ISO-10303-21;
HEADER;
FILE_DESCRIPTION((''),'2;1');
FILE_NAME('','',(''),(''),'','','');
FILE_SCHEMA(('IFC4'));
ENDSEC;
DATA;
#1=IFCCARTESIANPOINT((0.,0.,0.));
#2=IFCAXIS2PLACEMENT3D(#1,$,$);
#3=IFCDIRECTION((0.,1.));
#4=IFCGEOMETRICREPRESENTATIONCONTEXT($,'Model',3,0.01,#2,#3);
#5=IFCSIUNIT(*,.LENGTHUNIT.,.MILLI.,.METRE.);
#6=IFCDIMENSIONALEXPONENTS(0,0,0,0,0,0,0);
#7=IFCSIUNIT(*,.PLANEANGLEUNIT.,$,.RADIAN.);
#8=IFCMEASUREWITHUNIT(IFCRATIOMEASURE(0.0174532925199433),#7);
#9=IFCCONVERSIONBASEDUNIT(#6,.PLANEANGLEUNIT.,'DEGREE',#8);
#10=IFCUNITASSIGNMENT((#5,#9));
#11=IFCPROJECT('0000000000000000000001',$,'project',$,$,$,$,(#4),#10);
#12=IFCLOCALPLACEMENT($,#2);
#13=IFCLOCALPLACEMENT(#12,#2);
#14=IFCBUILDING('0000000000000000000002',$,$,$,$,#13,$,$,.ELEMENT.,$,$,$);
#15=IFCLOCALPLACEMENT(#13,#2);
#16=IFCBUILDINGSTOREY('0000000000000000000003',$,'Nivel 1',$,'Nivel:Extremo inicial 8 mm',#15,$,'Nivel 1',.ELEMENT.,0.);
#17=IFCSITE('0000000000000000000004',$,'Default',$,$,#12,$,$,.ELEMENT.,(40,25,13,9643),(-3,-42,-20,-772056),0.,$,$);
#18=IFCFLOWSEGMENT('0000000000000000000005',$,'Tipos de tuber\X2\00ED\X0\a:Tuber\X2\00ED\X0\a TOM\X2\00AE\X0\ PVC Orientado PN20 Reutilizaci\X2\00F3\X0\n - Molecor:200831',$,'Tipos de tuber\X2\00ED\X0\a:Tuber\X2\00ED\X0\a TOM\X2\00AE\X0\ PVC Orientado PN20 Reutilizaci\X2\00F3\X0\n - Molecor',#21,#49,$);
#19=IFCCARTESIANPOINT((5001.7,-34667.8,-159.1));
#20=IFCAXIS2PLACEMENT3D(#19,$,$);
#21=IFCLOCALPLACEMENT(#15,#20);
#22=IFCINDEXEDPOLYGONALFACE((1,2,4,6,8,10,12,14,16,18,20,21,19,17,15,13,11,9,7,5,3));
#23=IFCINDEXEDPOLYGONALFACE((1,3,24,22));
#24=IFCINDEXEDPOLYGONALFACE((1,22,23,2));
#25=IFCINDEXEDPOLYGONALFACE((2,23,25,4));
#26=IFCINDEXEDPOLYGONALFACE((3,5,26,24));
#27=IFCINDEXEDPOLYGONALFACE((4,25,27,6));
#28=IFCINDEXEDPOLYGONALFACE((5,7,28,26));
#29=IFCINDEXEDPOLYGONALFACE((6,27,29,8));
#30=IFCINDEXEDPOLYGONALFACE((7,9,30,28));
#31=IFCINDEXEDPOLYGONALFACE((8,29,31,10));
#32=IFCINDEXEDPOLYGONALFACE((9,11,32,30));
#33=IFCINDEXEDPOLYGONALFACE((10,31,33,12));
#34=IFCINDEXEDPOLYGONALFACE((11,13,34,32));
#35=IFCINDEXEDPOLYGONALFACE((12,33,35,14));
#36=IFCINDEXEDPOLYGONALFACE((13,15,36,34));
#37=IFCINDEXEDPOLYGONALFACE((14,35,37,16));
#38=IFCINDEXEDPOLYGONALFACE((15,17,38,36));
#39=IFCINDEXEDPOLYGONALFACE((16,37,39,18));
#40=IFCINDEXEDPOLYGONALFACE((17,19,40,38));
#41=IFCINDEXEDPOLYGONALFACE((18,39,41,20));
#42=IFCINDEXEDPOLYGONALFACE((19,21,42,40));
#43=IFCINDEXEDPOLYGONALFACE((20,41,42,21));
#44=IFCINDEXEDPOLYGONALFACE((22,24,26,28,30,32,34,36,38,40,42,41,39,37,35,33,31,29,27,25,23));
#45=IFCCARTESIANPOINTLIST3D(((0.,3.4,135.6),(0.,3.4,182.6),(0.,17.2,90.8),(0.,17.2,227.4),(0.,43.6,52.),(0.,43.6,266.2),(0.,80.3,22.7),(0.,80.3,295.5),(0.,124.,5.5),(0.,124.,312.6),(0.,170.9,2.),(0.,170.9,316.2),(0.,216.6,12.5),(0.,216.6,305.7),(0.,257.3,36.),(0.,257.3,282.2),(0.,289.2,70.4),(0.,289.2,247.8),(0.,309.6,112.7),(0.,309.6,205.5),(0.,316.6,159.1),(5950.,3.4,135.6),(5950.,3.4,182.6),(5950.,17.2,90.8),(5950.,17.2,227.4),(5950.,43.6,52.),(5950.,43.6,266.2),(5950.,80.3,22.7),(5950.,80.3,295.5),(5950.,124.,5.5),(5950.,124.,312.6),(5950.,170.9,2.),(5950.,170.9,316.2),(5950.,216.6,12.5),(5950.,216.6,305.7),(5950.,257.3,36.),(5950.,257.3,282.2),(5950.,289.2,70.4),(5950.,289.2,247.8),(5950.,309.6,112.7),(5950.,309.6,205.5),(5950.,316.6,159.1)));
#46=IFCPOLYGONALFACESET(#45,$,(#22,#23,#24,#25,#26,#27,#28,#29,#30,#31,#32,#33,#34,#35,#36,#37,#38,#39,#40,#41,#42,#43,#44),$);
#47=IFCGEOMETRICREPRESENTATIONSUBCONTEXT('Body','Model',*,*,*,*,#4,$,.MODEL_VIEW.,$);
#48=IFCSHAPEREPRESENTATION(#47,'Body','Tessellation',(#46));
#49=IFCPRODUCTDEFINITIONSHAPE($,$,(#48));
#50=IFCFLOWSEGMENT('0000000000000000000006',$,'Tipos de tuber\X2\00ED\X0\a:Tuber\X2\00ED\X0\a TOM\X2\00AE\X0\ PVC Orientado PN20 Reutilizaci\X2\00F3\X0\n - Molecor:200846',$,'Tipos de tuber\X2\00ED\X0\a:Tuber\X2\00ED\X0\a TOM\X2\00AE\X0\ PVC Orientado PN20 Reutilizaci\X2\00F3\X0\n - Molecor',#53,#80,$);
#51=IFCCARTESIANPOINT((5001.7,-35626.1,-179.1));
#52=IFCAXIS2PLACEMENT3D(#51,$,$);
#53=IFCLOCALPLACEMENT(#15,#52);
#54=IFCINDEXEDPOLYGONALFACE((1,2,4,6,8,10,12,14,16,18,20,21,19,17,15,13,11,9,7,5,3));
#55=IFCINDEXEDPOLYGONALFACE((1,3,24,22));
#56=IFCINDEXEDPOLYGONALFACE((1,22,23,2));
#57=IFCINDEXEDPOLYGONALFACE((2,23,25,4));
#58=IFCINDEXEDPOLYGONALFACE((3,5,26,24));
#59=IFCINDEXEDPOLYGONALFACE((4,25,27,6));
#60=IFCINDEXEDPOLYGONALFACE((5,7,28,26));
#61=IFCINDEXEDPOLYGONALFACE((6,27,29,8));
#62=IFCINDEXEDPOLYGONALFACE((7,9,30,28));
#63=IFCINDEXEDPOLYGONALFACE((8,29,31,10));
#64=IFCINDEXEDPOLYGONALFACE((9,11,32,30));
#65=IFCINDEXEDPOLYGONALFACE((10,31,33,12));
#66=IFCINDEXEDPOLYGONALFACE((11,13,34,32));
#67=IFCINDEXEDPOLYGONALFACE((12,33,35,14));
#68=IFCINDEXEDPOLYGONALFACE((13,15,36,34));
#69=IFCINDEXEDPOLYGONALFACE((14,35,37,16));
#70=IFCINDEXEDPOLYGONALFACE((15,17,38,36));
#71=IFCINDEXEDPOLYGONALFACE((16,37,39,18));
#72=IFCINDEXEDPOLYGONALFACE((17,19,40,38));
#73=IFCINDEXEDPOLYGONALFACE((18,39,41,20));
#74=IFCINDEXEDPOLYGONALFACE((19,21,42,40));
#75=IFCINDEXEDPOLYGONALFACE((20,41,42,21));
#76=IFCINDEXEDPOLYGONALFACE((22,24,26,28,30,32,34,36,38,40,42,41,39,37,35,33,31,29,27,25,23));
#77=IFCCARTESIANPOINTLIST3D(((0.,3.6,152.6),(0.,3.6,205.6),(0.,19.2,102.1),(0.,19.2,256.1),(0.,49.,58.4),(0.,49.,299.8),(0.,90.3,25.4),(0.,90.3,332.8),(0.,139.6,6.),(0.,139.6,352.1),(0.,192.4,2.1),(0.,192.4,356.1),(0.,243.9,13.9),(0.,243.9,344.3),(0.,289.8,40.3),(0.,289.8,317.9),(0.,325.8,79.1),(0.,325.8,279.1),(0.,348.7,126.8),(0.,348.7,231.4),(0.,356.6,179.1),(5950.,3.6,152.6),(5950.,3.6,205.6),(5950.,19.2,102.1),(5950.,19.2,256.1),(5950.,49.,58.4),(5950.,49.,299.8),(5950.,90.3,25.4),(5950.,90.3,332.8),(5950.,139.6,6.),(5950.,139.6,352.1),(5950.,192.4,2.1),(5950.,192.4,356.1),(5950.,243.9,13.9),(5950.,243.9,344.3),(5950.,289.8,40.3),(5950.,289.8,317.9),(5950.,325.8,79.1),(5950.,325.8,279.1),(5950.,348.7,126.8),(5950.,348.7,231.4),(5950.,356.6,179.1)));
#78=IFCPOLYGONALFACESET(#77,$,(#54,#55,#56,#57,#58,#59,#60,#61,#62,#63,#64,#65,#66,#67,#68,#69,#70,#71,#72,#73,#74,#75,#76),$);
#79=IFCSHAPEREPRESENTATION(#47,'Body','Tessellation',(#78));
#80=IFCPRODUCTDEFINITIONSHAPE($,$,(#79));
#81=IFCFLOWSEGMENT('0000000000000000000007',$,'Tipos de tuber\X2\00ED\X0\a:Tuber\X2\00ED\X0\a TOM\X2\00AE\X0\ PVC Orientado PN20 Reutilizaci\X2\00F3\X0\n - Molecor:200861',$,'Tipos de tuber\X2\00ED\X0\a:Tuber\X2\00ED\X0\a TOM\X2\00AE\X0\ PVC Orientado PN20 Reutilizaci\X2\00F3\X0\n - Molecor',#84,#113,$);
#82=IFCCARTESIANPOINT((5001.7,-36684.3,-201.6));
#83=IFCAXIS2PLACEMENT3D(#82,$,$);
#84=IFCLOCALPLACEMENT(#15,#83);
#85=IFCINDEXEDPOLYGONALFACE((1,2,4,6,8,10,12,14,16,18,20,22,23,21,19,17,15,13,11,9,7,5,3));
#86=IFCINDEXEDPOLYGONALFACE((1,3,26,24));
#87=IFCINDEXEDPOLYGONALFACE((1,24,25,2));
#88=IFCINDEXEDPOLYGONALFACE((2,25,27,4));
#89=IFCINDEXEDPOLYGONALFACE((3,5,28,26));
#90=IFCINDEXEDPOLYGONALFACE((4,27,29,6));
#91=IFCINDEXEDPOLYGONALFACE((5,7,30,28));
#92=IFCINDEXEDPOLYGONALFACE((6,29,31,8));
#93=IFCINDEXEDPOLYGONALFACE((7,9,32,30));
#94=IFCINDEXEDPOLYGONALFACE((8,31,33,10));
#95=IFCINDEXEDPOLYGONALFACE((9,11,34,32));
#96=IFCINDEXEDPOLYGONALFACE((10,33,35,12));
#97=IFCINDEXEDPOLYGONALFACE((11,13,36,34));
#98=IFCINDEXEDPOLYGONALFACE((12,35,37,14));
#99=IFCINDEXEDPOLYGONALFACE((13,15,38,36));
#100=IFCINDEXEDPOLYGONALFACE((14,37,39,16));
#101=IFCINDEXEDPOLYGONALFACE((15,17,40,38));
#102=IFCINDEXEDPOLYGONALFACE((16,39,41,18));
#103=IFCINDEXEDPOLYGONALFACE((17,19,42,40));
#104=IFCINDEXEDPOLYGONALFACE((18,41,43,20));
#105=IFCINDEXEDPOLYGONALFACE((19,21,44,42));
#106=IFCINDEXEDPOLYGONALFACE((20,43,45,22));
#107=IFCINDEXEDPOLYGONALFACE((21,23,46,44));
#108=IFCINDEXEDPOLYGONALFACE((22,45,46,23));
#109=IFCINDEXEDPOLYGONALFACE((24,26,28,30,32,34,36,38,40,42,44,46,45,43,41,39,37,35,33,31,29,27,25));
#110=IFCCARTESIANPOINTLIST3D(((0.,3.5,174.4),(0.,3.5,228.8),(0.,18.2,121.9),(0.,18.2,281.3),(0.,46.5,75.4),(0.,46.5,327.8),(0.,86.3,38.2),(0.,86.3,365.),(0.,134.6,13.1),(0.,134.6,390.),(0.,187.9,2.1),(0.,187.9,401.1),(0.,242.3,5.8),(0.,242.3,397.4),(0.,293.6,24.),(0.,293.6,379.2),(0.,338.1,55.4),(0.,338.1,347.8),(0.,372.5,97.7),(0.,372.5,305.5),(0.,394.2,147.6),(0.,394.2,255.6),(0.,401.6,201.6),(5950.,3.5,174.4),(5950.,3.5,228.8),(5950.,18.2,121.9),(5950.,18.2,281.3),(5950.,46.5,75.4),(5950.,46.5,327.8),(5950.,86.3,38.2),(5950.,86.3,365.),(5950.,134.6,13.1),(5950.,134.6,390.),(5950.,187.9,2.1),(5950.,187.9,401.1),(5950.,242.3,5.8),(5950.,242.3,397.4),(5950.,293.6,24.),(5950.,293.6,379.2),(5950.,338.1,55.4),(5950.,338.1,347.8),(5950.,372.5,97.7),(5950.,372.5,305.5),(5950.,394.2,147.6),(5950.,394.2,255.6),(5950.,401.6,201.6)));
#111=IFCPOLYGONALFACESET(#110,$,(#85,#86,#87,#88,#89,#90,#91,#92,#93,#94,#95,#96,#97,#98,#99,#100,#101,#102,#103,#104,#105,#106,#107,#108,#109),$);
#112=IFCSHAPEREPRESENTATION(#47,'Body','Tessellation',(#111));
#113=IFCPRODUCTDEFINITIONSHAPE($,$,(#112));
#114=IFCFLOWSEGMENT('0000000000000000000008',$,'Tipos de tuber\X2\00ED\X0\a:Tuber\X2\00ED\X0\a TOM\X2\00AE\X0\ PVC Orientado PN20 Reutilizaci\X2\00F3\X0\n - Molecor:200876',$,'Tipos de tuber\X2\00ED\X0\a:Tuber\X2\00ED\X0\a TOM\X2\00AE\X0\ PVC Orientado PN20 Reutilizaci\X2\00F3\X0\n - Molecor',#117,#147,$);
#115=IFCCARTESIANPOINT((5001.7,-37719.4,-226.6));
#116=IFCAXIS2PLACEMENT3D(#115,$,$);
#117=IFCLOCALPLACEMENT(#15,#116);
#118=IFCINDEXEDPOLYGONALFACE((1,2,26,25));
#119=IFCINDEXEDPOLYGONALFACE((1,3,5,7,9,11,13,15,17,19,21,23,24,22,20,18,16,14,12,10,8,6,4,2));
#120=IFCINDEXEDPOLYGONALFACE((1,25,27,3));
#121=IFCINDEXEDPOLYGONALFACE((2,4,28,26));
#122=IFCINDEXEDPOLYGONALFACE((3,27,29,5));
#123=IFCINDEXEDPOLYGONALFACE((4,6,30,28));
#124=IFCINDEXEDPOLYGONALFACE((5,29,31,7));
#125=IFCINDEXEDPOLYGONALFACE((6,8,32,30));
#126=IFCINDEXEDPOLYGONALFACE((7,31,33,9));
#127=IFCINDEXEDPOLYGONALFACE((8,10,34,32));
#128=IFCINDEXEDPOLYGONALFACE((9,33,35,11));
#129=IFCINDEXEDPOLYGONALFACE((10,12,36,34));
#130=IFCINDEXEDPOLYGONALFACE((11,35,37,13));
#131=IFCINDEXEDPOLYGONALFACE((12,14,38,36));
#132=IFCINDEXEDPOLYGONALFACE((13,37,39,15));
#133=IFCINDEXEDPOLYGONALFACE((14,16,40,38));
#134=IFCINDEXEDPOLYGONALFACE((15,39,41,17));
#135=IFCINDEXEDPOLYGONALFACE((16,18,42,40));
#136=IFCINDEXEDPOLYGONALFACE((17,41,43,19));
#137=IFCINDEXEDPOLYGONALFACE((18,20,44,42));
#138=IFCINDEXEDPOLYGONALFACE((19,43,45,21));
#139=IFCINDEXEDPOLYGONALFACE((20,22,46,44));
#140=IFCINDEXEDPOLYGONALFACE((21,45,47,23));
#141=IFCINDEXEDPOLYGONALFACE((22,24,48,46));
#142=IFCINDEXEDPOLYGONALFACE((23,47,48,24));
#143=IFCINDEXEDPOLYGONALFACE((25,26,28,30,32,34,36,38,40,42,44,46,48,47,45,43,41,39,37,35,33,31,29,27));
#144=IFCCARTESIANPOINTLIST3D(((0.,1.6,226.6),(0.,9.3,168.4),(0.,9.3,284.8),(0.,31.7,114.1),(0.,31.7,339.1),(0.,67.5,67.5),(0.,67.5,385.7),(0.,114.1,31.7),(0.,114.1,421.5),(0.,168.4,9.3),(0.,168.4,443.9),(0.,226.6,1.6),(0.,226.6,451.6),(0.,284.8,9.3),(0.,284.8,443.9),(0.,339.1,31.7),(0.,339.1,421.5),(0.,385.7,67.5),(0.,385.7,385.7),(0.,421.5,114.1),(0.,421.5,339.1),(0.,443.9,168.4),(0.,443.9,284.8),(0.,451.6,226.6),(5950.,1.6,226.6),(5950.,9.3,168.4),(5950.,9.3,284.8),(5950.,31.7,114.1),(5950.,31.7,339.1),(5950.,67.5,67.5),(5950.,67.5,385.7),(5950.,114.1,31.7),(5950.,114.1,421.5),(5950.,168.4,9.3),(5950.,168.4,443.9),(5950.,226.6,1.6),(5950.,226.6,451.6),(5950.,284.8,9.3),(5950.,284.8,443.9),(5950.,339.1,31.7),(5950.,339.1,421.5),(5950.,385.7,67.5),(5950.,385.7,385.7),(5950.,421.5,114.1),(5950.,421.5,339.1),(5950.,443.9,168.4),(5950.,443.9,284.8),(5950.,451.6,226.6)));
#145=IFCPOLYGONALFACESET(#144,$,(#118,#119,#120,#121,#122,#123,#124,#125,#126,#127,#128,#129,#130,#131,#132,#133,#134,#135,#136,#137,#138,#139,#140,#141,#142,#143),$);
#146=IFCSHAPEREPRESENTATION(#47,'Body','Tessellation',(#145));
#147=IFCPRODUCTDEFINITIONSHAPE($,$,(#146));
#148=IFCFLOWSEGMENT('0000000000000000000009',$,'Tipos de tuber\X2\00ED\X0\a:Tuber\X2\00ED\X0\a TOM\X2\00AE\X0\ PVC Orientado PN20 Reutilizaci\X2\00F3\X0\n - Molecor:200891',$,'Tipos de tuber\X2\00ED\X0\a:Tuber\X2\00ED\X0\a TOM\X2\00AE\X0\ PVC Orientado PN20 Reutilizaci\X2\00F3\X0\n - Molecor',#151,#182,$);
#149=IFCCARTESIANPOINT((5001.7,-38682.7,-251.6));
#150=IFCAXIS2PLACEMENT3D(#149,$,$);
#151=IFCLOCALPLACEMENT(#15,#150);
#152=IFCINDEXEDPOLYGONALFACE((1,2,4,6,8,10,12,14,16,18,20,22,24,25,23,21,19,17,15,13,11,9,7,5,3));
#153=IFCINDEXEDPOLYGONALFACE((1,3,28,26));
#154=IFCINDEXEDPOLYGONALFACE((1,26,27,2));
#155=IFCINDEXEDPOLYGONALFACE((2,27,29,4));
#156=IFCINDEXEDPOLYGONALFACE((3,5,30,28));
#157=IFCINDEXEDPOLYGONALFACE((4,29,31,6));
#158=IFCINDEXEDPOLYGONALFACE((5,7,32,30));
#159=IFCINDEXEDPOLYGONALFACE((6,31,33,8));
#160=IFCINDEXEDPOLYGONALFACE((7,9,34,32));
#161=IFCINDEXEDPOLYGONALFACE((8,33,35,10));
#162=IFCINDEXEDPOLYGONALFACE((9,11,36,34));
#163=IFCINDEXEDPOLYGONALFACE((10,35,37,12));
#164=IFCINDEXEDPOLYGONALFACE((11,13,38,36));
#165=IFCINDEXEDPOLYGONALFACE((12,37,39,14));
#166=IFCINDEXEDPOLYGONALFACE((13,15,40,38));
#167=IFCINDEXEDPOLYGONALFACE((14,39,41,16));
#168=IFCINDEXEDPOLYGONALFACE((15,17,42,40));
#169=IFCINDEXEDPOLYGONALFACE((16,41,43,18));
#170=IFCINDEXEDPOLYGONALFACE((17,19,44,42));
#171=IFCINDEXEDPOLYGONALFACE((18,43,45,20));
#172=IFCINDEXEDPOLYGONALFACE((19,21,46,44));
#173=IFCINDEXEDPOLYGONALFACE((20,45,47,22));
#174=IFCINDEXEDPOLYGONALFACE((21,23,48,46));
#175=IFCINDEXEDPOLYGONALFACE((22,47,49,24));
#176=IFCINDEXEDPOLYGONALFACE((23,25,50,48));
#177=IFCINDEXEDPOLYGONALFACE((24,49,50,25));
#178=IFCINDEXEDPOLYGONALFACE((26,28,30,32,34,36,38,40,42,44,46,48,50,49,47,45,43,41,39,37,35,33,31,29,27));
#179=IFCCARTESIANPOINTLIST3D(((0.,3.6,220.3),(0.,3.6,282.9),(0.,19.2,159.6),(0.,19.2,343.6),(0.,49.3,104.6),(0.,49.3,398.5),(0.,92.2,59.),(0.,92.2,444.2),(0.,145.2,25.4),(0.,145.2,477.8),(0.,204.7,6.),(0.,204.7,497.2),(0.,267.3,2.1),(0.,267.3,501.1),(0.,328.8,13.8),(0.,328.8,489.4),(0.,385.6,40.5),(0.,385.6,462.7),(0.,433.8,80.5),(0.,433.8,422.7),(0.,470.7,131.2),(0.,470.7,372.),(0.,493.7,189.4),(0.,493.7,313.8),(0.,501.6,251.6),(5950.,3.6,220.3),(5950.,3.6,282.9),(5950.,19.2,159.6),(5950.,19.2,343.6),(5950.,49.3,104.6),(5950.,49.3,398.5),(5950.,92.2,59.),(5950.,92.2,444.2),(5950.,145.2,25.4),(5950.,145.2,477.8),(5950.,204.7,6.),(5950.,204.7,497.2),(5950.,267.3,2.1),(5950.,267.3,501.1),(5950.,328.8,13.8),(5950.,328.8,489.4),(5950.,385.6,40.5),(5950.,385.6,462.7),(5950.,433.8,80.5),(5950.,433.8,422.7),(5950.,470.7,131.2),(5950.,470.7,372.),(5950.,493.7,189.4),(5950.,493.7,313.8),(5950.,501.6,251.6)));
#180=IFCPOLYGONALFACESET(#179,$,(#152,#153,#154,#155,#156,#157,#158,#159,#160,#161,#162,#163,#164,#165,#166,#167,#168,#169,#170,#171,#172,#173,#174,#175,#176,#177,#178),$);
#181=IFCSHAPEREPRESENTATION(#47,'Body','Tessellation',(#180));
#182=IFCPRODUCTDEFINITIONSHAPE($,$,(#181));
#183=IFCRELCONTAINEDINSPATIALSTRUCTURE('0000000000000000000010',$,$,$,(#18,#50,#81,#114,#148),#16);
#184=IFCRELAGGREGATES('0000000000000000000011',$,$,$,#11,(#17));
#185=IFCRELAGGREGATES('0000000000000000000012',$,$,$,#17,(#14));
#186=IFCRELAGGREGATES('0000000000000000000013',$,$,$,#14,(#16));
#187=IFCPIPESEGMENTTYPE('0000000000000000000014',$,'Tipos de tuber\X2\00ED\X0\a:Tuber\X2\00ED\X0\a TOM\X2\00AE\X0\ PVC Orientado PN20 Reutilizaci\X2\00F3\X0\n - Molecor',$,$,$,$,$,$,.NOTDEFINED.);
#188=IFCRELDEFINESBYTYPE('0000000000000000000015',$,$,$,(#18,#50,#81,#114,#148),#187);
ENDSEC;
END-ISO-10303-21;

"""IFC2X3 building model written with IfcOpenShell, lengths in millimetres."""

from ifc_helpers import new_model, entity, si_unit, converted_unit, direction, frame, frame_2d, origin, place, context, subcontext, project, spatial, circle, extrude, type_object, element, save


model = new_model("IFC2X3")

# Units and contexts
model_context = context("Model", 3, precision=0.01, world=origin(), true_north=direction((0.0, 1.0)))
body_context = subcontext(model_context, "Body", "Model", "MODEL_VIEW")
ifc_project = project(units=[si_unit("LENGTHUNIT", "METRE", prefix="MILLI"), converted_unit("PLANEANGLEUNIT", "DEGREE", entity("IfcRatioMeasure", 0.0174532925199433), si_unit("PLANEANGLEUNIT", "RADIAN"), dimensions=[0, 0, 0, 0, 0, 0, 0])], contexts=[model_context])

# Site, building, storey
site_placement = place(None, origin())
site = spatial("IfcSite", under=ifc_project, at=site_placement, Name="Default", CompositionType="ELEMENT", RefLatitude=(40, 25, 13, 9643), RefLongitude=(-3, -42, -20, -772056), RefElevation=0.0)
building_placement = place(site_placement, origin())
building = spatial("IfcBuilding", under=site, at=building_placement, CompositionType="ELEMENT")
storey_placement = place(building_placement, origin())
storey = spatial("IfcBuildingStorey", under=building, at=storey_placement, Name="Nivel 1", ObjectType="Nivel:Extremo inicial 8 mm", LongName="Nivel 1", CompositionType="ELEMENT", Elevation=0.0)

# Flow segments
pipe_segment_type_1 = type_object("IfcPipeSegmentType", Name="Tipos de tubería:Tubería TOM® PVC Orientado PN20 Reutilización - Molecor", PredefinedType="NOTDEFINED")
flow_segment_1_placement = place(storey_placement, frame((5001.7, -34667.8, -159.1)))
element("IfcFlowSegment", 1, at=flow_segment_1_placement, inside=storey, type_object=pipe_segment_type_1, Name="Tipos de tubería:Tubería TOM® PVC Orientado PN20 Reutilización - Molecor:200831", ObjectType="Tipos de tubería:Tubería TOM® PVC Orientado PN20 Reutilización - Molecor", context=body_context, shape_type="SweptSolid", body=[
    extrude(circle(Radius=157.5, at=frame_2d((0.0, 0.0), x_axis=(1.0, 0.0))), frame((0.0, 159.1, 159.1), z_axis=(1.0, 0.0, 0.0), x_axis=(0.0, 1.0, 0.0)), (0.0, 0.0, 1.0), 5950.0),
])
flow_segment_2_placement = place(storey_placement, frame((5001.7, -35626.1, -179.1)))
element("IfcFlowSegment", 2, at=flow_segment_2_placement, inside=storey, type_object=pipe_segment_type_1, Name="Tipos de tubería:Tubería TOM® PVC Orientado PN20 Reutilización - Molecor:200846", ObjectType="Tipos de tubería:Tubería TOM® PVC Orientado PN20 Reutilización - Molecor", context=body_context, shape_type="SweptSolid", body=[
    extrude(circle(Radius=177.5, at=frame_2d((0.0, 0.0), x_axis=(1.0, 0.0))), frame((0.0, 179.1, 179.1), z_axis=(1.0, 0.0, 0.0), x_axis=(0.0, 1.0, 0.0)), (0.0, 0.0, 1.0), 5950.0),
])
flow_segment_3_placement = place(storey_placement, frame((5001.7, -36684.3, -201.6)))
element("IfcFlowSegment", 3, at=flow_segment_3_placement, inside=storey, type_object=pipe_segment_type_1, Name="Tipos de tubería:Tubería TOM® PVC Orientado PN20 Reutilización - Molecor:200861", ObjectType="Tipos de tubería:Tubería TOM® PVC Orientado PN20 Reutilización - Molecor", context=body_context, shape_type="SweptSolid", body=[
    extrude(circle(Radius=200.0, at=frame_2d((0.0, 0.0), x_axis=(1.0, 0.0))), frame((0.0, 201.6, 201.6), z_axis=(1.0, 0.0, 0.0), x_axis=(0.0, 1.0, 0.0)), (0.0, 0.0, 1.0), 5950.0),
])
flow_segment_4_placement = place(storey_placement, frame((5001.7, -37719.4, -226.6)))
element("IfcFlowSegment", 4, at=flow_segment_4_placement, inside=storey, type_object=pipe_segment_type_1, Name="Tipos de tubería:Tubería TOM® PVC Orientado PN20 Reutilización - Molecor:200876", ObjectType="Tipos de tubería:Tubería TOM® PVC Orientado PN20 Reutilización - Molecor", context=body_context, shape_type="SweptSolid", body=[
    extrude(circle(Radius=225.0, at=frame_2d((0.0, 0.0), x_axis=(1.0, 0.0))), frame((0.0, 226.6, 226.6), z_axis=(1.0, 0.0, 0.0), x_axis=(0.0, 1.0, 0.0)), (0.0, 0.0, 1.0), 5950.0),
])
flow_segment_5_placement = place(storey_placement, frame((5001.7, -38682.7, -251.6)))
element("IfcFlowSegment", 5, at=flow_segment_5_placement, inside=storey, type_object=pipe_segment_type_1, Name="Tipos de tubería:Tubería TOM® PVC Orientado PN20 Reutilización - Molecor:200891", ObjectType="Tipos de tubería:Tubería TOM® PVC Orientado PN20 Reutilización - Molecor", context=body_context, shape_type="SweptSolid", body=[
    extrude(circle(Radius=250.0, at=frame_2d((0.0, 0.0), x_axis=(1.0, 0.0))), frame((0.0, 251.6, 251.6), z_axis=(1.0, 0.0, 0.0), x_axis=(0.0, 1.0, 0.0)), (0.0, 0.0, 1.0), 5950.0),
])

save(model, "model.ifc")
